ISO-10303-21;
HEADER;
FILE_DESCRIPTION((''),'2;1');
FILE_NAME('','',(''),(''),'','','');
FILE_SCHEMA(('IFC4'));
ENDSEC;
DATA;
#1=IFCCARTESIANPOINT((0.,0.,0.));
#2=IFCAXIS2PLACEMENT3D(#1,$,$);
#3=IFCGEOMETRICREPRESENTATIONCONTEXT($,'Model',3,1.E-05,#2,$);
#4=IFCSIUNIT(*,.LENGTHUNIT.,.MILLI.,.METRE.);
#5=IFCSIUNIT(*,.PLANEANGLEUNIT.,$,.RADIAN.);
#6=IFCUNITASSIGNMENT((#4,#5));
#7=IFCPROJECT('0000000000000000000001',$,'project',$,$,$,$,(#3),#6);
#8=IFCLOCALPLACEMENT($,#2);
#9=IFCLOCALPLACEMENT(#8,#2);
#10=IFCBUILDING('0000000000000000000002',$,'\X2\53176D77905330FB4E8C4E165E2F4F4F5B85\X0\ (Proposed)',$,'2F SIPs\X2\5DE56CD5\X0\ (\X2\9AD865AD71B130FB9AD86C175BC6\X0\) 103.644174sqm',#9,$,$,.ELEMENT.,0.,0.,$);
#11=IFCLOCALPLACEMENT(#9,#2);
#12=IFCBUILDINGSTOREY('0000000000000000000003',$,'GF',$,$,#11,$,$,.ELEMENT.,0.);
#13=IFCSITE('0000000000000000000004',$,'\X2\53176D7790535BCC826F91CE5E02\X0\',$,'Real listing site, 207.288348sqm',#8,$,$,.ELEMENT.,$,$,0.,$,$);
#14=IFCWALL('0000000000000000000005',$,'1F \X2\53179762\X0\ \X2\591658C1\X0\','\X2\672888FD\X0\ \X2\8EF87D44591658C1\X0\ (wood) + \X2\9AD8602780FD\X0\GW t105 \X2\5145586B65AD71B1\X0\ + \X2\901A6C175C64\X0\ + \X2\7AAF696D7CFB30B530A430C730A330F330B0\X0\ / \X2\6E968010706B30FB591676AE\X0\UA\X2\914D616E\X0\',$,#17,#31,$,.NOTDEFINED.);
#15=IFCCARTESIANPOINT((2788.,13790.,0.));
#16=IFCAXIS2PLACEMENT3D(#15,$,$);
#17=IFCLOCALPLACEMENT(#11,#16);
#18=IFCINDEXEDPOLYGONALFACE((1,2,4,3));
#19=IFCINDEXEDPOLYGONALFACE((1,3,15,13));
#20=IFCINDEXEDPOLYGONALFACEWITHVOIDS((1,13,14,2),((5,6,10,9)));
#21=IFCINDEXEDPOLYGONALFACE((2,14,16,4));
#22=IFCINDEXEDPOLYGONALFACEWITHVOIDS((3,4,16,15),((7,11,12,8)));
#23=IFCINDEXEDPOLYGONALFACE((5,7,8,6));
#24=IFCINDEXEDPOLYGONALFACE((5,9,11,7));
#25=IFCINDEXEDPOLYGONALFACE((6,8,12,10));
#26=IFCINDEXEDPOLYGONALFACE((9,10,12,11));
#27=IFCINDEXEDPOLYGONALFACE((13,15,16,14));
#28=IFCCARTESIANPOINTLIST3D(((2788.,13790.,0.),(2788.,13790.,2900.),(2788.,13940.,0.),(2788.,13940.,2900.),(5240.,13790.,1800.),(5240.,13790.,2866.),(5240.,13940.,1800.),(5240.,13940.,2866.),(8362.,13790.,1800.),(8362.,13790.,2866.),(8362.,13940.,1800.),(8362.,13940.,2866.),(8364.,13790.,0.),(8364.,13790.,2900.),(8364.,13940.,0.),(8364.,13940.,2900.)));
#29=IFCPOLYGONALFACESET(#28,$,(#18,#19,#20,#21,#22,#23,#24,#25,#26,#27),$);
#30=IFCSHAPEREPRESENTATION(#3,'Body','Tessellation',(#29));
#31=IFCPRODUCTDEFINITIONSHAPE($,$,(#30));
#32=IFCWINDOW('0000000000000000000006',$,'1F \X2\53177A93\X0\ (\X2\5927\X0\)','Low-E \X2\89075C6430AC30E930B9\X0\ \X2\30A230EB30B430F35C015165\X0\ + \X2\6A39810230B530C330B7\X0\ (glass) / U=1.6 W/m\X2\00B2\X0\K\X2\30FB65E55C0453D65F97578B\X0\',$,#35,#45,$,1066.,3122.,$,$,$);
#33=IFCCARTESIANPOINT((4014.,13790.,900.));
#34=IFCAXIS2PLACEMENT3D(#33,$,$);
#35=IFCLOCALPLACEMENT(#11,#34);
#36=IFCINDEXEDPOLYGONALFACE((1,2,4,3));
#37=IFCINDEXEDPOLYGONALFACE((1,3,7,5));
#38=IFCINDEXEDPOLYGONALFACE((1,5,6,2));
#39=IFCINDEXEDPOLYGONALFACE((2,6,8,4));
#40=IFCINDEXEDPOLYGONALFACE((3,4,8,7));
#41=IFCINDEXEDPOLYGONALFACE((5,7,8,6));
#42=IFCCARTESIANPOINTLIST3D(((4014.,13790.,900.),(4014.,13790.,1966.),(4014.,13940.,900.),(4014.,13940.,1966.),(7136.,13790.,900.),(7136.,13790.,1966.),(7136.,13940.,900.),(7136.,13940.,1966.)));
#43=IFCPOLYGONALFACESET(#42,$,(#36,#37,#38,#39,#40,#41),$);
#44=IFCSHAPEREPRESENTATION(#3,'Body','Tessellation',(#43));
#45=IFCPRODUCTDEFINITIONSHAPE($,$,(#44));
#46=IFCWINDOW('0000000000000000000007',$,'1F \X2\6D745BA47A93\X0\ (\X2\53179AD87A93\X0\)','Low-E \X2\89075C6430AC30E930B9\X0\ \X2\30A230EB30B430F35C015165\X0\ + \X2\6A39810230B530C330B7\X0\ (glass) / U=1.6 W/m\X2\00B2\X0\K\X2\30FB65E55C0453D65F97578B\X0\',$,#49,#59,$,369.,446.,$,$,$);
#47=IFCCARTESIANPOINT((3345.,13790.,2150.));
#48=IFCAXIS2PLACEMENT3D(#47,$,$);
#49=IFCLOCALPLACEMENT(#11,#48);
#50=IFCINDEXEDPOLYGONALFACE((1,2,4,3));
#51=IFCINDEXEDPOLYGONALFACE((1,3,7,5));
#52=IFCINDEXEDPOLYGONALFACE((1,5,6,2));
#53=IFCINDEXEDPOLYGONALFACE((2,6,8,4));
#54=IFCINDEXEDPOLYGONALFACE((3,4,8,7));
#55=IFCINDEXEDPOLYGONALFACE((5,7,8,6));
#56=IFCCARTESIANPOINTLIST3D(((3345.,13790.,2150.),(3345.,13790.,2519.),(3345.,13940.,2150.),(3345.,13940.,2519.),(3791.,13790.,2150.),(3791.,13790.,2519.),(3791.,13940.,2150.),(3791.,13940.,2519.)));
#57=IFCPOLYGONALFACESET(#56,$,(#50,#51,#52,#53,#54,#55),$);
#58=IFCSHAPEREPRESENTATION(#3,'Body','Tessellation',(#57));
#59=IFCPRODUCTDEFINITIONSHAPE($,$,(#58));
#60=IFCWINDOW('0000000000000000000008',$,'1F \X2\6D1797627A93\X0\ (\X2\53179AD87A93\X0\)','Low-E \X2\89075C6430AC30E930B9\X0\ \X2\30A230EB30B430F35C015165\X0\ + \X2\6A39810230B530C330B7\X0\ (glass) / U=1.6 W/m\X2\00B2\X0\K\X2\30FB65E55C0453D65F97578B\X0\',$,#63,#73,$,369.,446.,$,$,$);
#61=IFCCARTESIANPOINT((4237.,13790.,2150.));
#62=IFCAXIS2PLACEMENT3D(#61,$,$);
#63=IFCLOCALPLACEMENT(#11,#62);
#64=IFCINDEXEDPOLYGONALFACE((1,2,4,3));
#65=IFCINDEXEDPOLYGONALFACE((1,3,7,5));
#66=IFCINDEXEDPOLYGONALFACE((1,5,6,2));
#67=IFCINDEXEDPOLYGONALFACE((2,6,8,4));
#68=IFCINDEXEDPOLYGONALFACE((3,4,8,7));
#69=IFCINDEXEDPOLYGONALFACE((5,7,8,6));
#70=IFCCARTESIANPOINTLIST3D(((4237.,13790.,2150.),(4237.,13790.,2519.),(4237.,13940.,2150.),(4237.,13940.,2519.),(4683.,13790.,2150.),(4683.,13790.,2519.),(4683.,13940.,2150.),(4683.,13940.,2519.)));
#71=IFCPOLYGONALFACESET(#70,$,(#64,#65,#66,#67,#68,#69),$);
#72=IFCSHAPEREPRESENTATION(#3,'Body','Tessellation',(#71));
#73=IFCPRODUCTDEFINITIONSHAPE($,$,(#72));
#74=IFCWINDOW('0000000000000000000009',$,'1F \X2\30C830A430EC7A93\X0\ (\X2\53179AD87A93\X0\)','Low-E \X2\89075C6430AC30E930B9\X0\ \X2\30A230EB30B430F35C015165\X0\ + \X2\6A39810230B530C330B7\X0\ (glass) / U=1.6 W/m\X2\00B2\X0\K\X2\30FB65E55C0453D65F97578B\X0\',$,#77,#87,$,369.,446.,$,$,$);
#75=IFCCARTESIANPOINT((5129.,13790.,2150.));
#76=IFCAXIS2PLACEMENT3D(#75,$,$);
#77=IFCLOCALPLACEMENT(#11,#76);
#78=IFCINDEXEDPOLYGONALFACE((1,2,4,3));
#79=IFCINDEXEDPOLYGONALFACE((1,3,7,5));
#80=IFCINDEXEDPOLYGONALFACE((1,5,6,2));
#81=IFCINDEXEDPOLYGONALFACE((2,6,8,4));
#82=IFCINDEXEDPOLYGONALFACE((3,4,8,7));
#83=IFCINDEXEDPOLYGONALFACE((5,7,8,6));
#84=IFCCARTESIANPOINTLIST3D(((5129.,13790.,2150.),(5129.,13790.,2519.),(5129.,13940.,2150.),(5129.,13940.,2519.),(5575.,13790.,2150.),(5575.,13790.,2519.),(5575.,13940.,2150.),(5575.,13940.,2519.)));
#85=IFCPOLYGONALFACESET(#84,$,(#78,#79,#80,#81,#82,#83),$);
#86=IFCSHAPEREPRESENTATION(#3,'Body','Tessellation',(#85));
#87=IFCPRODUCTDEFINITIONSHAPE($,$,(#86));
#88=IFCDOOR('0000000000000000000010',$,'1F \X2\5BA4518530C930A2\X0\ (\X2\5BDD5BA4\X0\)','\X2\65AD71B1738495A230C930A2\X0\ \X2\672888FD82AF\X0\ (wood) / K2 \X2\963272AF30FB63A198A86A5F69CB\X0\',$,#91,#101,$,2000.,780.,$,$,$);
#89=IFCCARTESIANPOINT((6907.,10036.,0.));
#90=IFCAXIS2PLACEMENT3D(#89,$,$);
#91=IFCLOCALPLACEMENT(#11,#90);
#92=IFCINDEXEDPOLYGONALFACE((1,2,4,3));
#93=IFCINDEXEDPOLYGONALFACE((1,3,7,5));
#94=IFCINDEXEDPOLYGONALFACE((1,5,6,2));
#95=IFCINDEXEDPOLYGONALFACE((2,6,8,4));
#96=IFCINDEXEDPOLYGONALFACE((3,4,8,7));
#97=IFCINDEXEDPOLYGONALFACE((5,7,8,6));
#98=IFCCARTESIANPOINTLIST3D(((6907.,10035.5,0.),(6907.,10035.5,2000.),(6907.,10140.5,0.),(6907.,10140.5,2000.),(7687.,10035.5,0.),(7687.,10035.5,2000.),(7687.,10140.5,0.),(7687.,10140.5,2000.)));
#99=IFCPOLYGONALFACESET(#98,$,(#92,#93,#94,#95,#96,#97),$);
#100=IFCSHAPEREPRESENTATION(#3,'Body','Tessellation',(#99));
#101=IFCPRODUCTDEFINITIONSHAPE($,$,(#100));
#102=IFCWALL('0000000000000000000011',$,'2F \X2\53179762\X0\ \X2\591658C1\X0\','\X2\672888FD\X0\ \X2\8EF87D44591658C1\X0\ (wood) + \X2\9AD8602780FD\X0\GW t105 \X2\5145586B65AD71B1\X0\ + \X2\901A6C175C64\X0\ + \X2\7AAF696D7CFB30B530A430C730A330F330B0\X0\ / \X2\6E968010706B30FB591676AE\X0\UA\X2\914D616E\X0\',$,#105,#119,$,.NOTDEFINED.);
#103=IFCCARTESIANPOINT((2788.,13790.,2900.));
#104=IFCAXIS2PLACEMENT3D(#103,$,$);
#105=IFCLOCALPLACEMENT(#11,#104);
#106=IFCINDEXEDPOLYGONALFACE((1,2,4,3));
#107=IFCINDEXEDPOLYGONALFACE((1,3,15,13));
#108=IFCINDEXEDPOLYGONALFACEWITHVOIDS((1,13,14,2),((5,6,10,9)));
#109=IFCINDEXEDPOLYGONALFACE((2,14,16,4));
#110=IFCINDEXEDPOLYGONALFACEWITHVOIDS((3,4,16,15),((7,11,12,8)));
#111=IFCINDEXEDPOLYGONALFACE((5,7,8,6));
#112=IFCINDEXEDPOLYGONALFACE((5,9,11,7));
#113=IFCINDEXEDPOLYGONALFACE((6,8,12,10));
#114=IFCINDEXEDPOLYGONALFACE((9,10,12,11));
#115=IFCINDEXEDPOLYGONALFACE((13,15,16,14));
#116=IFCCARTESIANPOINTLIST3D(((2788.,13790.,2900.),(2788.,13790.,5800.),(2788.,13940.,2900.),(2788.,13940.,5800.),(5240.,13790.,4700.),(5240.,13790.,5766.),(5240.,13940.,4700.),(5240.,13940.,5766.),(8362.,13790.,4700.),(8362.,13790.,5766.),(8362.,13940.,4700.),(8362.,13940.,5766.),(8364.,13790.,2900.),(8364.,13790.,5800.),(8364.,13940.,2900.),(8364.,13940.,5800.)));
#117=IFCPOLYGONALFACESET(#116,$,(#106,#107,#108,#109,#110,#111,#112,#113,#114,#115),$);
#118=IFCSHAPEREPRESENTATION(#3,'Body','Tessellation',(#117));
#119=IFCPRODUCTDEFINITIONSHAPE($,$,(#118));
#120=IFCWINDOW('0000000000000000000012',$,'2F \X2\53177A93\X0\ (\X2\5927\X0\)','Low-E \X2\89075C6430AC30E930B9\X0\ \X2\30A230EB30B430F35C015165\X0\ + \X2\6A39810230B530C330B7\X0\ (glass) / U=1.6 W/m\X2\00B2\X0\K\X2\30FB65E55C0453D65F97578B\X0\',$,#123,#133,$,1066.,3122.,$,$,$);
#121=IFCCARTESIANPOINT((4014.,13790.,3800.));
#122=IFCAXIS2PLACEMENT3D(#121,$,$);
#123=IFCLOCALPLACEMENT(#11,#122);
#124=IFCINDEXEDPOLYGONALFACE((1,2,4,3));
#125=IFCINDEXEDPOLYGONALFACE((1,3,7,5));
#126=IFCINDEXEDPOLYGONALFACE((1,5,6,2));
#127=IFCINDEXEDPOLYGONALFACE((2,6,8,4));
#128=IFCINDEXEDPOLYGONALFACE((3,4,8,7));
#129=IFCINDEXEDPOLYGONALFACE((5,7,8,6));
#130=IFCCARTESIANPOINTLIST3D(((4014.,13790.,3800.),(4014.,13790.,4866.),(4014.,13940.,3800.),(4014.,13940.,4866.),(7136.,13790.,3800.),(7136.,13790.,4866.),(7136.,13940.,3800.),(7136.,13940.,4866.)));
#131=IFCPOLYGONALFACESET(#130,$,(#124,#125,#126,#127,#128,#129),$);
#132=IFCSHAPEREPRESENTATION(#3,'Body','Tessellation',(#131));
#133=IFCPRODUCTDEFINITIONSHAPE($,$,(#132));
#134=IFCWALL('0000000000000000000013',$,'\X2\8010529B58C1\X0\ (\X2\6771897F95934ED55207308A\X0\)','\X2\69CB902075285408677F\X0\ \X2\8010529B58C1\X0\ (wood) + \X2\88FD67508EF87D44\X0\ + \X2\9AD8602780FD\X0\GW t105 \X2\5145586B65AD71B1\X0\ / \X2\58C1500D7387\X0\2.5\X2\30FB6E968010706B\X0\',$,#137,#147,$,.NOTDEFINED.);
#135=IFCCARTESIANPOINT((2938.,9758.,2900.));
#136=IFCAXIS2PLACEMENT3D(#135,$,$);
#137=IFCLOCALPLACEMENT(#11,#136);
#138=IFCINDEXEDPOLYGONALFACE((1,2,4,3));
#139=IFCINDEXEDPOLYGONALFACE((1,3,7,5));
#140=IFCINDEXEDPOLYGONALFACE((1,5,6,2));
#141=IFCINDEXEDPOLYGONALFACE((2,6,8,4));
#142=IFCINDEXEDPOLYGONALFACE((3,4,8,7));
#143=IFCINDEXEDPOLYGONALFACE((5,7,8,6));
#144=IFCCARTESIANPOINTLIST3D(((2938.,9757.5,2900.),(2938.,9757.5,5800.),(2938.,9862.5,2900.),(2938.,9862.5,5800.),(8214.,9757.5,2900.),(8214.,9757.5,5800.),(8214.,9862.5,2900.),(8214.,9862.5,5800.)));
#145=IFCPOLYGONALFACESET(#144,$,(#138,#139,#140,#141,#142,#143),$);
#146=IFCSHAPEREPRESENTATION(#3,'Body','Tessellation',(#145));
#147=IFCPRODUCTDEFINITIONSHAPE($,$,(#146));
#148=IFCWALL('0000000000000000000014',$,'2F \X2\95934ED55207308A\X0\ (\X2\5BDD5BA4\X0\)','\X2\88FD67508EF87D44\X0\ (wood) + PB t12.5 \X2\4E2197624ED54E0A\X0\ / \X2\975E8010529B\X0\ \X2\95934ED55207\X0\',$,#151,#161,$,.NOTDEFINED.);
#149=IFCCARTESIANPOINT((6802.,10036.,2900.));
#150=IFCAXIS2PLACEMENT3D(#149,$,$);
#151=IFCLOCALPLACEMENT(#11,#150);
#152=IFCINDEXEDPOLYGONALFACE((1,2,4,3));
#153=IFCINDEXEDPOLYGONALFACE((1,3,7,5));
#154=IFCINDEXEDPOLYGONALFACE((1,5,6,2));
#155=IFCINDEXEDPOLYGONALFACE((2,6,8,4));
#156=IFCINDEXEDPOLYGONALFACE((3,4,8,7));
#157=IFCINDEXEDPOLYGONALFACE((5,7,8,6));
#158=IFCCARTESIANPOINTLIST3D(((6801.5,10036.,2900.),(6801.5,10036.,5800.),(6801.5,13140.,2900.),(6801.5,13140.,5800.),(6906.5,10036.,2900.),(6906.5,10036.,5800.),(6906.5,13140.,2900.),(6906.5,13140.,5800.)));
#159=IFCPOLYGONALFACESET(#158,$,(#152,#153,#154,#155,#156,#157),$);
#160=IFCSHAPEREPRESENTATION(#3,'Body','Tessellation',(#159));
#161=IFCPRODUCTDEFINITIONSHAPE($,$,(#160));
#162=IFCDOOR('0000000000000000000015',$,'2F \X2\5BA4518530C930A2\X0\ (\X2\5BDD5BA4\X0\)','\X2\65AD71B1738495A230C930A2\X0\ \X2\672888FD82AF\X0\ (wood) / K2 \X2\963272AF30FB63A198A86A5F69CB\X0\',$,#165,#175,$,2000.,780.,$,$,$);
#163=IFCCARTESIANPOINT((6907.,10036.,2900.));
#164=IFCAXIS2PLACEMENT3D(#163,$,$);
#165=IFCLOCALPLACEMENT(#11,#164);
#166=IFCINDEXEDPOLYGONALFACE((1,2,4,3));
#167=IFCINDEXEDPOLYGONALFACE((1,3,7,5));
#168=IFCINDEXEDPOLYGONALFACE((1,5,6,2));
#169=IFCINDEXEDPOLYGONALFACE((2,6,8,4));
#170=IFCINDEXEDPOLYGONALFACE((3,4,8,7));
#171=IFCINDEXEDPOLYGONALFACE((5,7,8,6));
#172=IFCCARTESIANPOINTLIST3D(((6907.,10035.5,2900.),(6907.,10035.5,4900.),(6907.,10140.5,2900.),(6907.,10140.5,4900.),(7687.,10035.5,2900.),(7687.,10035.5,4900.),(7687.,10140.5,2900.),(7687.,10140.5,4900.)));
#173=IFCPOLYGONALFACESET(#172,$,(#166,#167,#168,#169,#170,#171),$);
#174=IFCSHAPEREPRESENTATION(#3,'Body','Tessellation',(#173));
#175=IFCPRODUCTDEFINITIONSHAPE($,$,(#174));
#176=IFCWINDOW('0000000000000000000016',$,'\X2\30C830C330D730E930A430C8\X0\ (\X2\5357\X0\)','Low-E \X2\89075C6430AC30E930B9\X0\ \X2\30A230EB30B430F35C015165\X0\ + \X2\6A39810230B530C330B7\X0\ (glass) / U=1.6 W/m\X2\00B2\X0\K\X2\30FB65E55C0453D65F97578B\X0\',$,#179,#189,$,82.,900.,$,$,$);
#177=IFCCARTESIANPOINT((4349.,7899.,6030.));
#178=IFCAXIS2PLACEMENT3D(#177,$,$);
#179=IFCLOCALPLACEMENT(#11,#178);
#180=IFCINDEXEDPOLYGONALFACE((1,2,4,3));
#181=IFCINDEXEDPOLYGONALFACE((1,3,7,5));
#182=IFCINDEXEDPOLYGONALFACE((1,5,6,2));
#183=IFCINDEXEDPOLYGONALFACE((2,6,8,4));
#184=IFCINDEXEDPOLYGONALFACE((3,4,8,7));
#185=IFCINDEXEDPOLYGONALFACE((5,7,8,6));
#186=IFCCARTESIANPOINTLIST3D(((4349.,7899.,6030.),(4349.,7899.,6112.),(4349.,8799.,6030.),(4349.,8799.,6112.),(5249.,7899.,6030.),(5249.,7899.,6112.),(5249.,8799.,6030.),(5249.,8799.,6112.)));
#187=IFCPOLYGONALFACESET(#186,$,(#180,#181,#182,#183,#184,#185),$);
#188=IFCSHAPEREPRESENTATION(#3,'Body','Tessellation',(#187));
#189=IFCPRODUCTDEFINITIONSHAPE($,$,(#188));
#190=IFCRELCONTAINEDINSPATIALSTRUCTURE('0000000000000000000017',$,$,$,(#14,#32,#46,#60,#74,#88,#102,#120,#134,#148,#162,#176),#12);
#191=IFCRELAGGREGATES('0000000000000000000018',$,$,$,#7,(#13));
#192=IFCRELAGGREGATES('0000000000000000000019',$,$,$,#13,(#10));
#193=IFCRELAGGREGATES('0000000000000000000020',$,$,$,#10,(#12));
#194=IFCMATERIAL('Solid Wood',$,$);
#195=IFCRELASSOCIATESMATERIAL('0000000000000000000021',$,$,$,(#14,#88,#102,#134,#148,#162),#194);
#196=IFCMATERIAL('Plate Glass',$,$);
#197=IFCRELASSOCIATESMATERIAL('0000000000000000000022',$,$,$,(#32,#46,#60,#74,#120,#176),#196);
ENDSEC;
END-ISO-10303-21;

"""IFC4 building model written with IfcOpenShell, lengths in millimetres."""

from ifc_helpers import new_model, si_unit, frame, frame_2d, origin, place, context, project, spatial, rectangle, extrude, material, element, fill, save


model = new_model("IFC4")

# Units and contexts
model_context = context("Model", 3, precision=1e-05, world=origin())
ifc_project = project(units=[si_unit("LENGTHUNIT", "METRE", prefix="MILLI"), si_unit("PLANEANGLEUNIT", "RADIAN")], contexts=[model_context])

# Site, building, storey
site_placement = place(None, origin())
site = spatial("IfcSite", under=ifc_project, at=site_placement, Name="北海道富良野市", ObjectType="Real listing site, 207.288348sqm", CompositionType="ELEMENT", RefElevation=0.0)
building_placement = place(site_placement, origin())
building = spatial("IfcBuilding", under=site, at=building_placement, Name="北海道・二世帯住宅 (Proposed)", ObjectType="2F SIPs工法 (高断熱・高気密) 103.644174sqm", CompositionType="ELEMENT", ElevationOfRefHeight=0.0, ElevationOfTerrain=0.0)
storey_placement = place(building_placement, origin())
storey = spatial("IfcBuildingStorey", under=building, at=storey_placement, Name="GF", CompositionType="ELEMENT", Elevation=0.0)

# Wall, openings, windows
ifc_material_1 = material(Name="Solid Wood")
wall_1_placement = place(storey_placement, frame((2788.0, 13790.0, 0.0)))
wall_1 = element("IfcWall", 1, at=wall_1_placement, inside=storey, material=ifc_material_1, Name="1F 北面 外壁", Description="木製 軸組外壁 (wood) + 高性能GW t105 充填断熱 + 通気層 + 窯業系サイディング / 準耐火・外皮UA配慮", PredefinedType="NOTDEFINED", context=model_context, shape_type="SweptSolid", body=[
    extrude(rectangle(XDim=5576.0, YDim=150.0, at=frame_2d((2788.0, 75.0))), frame((2788.0, 13790.0, 0.0)), (0.0, 0.0, 1.0), 2900.0),
])
opening_1_placement = place(storey_placement, frame((4014.0, 13790.0, 900.0)))
opening_1 = element("IfcOpeningElement", 2, at=opening_1_placement, cuts=wall_1, PredefinedType="NOTDEFINED", context=model_context, shape_type="SweptSolid", body=[
    extrude(rectangle(XDim=3122.0, YDim=150.0, at=frame_2d((1561.0, 75.0))), frame((4014.0, 13790.0, 900.0)), (0.0, 0.0, 1.0), 1066.0),
])
opening_2_placement = place(storey_placement, frame((3345.0, 13790.0, 2150.0)))
opening_2 = element("IfcOpeningElement", 3, at=opening_2_placement, cuts=wall_1, PredefinedType="NOTDEFINED", context=model_context, shape_type="SweptSolid", body=[
    extrude(rectangle(XDim=446.0, YDim=150.0, at=frame_2d((223.0, 75.0))), frame((3345.0, 13790.0, 2150.0)), (0.0, 0.0, 1.0), 369.0),
])
opening_3_placement = place(storey_placement, frame((4237.0, 13790.0, 2150.0)))
opening_3 = element("IfcOpeningElement", 4, at=opening_3_placement, cuts=wall_1, PredefinedType="NOTDEFINED", context=model_context, shape_type="SweptSolid", body=[
    extrude(rectangle(XDim=446.0, YDim=150.0, at=frame_2d((223.0, 75.0))), frame((4237.0, 13790.0, 2150.0)), (0.0, 0.0, 1.0), 369.0),
])
opening_4_placement = place(storey_placement, frame((5129.0, 13790.0, 2150.0)))
opening_4 = element("IfcOpeningElement", 5, at=opening_4_placement, cuts=wall_1, PredefinedType="NOTDEFINED", context=model_context, shape_type="SweptSolid", body=[
    extrude(rectangle(XDim=446.0, YDim=150.0, at=frame_2d((223.0, 75.0))), frame((5129.0, 13790.0, 2150.0)), (0.0, 0.0, 1.0), 369.0),
])
ifc_material_2 = material(Name="Plate Glass")
window_1_placement = place(storey_placement, frame((4014.0, 13790.0, 900.0)))
window_1 = element("IfcWindow", 6, at=window_1_placement, inside=storey, material=ifc_material_2, Name="1F 北窓 (大)", Description="Low-E 複層ガラス アルゴン封入 + 樹脂サッシ (glass) / U=1.6 W/m²K・日射取得型", OverallHeight=1066.0, OverallWidth=3122.0, context=model_context, shape_type="SweptSolid", body=[
    extrude(rectangle(XDim=3122.0, YDim=150.0, at=frame_2d((1561.0, 75.0))), frame((4014.0, 13790.0, 900.0)), (0.0, 0.0, 1.0), 1066.0),
])
fill(opening_1, window_1)
window_2_placement = place(storey_placement, frame((3345.0, 13790.0, 2150.0)))
window_2 = element("IfcWindow", 7, at=window_2_placement, inside=storey, material=ifc_material_2, Name="1F 浴室窓 (北高窓)", Description="Low-E 複層ガラス アルゴン封入 + 樹脂サッシ (glass) / U=1.6 W/m²K・日射取得型", OverallHeight=369.0, OverallWidth=446.0, context=model_context, shape_type="SweptSolid", body=[
    extrude(rectangle(XDim=446.0, YDim=150.0, at=frame_2d((223.0, 75.0))), frame((3345.0, 13790.0, 2150.0)), (0.0, 0.0, 1.0), 369.0),
])
fill(opening_2, window_2)
window_3_placement = place(storey_placement, frame((4237.0, 13790.0, 2150.0)))
window_3 = element("IfcWindow", 8, at=window_3_placement, inside=storey, material=ifc_material_2, Name="1F 洗面窓 (北高窓)", Description="Low-E 複層ガラス アルゴン封入 + 樹脂サッシ (glass) / U=1.6 W/m²K・日射取得型", OverallHeight=369.0, OverallWidth=446.0, context=model_context, shape_type="SweptSolid", body=[
    extrude(rectangle(XDim=446.0, YDim=150.0, at=frame_2d((223.0, 75.0))), frame((4237.0, 13790.0, 2150.0)), (0.0, 0.0, 1.0), 369.0),
])
fill(opening_3, window_3)
window_4_placement = place(storey_placement, frame((5129.0, 13790.0, 2150.0)))
window_4 = element("IfcWindow", 9, at=window_4_placement, inside=storey, material=ifc_material_2, Name="1F トイレ窓 (北高窓)", Description="Low-E 複層ガラス アルゴン封入 + 樹脂サッシ (glass) / U=1.6 W/m²K・日射取得型", OverallHeight=369.0, OverallWidth=446.0, context=model_context, shape_type="SweptSolid", body=[
    extrude(rectangle(XDim=446.0, YDim=150.0, at=frame_2d((223.0, 75.0))), frame((5129.0, 13790.0, 2150.0)), (0.0, 0.0, 1.0), 369.0),
])
fill(opening_4, window_4)

# Door
door_1_placement = place(storey_placement, frame((6907.0, 10036.0, 0.0)))
element("IfcDoor", 10, at=door_1_placement, inside=storey, material=ifc_material_1, Name="1F 室内ドア (寝室)", Description="断熱玄関ドア 木製芯 (wood) / K2 防犯・採風機構", OverallHeight=2000.0, OverallWidth=780.0, context=model_context, shape_type="SweptSolid", body=[
    extrude(rectangle(XDim=780.0, YDim=105.0, at=frame_2d((390.0, 52.0))), frame((6907.0, 10036.0, 0.0)), (0.0, 0.0, 1.0), 2000.0),
])

# Wall, opening, window
wall_2_placement = place(storey_placement, frame((2788.0, 13790.0, 2900.0)))
wall_2 = element("IfcWall", 11, at=wall_2_placement, inside=storey, material=ifc_material_1, Name="2F 北面 外壁", Description="木製 軸組外壁 (wood) + 高性能GW t105 充填断熱 + 通気層 + 窯業系サイディング / 準耐火・外皮UA配慮", PredefinedType="NOTDEFINED", context=model_context, shape_type="SweptSolid", body=[
    extrude(rectangle(XDim=5576.0, YDim=150.0, at=frame_2d((2788.0, 75.0))), frame((2788.0, 13790.0, 2900.0)), (0.0, 0.0, 1.0), 2900.0),
])
opening_5_placement = place(storey_placement, frame((4014.0, 13790.0, 3800.0)))
opening_5 = element("IfcOpeningElement", 12, at=opening_5_placement, cuts=wall_2, PredefinedType="NOTDEFINED", context=model_context, shape_type="SweptSolid", body=[
    extrude(rectangle(XDim=3122.0, YDim=150.0, at=frame_2d((1561.0, 75.0))), frame((4014.0, 13790.0, 3800.0)), (0.0, 0.0, 1.0), 1066.0),
])
window_5_placement = place(storey_placement, frame((4014.0, 13790.0, 3800.0)))
window_5 = element("IfcWindow", 13, at=window_5_placement, inside=storey, material=ifc_material_2, Name="2F 北窓 (大)", Description="Low-E 複層ガラス アルゴン封入 + 樹脂サッシ (glass) / U=1.6 W/m²K・日射取得型", OverallHeight=1066.0, OverallWidth=3122.0, context=model_context, shape_type="SweptSolid", body=[
    extrude(rectangle(XDim=3122.0, YDim=150.0, at=frame_2d((1561.0, 75.0))), frame((4014.0, 13790.0, 3800.0)), (0.0, 0.0, 1.0), 1066.0),
])
fill(opening_5, window_5)

# Walls
wall_3_placement = place(storey_placement, frame((2938.0, 9758.0, 2900.0)))
element("IfcWall", 14, at=wall_3_placement, inside=storey, material=ifc_material_1, Name="耐力壁 (東西間仕切り)", Description="構造用合板 耐力壁 (wood) + 製材軸組 + 高性能GW t105 充填断熱 / 壁倍率2.5・準耐火", PredefinedType="NOTDEFINED", context=model_context, shape_type="SweptSolid", body=[
    extrude(rectangle(XDim=5276.0, YDim=105.0, at=frame_2d((2638.0, 52.0))), frame((2938.0, 9758.0, 2900.0)), (0.0, 0.0, 1.0), 2900.0),
])
wall_4_placement = place(storey_placement, frame((6802.0, 10036.0, 2900.0)))
element("IfcWall", 15, at=wall_4_placement, inside=storey, material=ifc_material_1, Name="2F 間仕切り (寝室)", Description="製材軸組 (wood) + PB t12.5 両面仕上 / 非耐力 間仕切", PredefinedType="NOTDEFINED", context=model_context, shape_type="SweptSolid", body=[
    extrude(rectangle(XDim=105.0, YDim=3104.0, at=frame_2d((52.0, 1552.0))), frame((6802.0, 10036.0, 2900.0)), (0.0, 0.0, 1.0), 2900.0),
])

# Door
door_2_placement = place(storey_placement, frame((6907.0, 10036.0, 2900.0)))
element("IfcDoor", 16, at=door_2_placement, inside=storey, material=ifc_material_1, Name="2F 室内ドア (寝室)", Description="断熱玄関ドア 木製芯 (wood) / K2 防犯・採風機構", OverallHeight=2000.0, OverallWidth=780.0, context=model_context, shape_type="SweptSolid", body=[
    extrude(rectangle(XDim=780.0, YDim=105.0, at=frame_2d((390.0, 52.0))), frame((6907.0, 10036.0, 2900.0)), (0.0, 0.0, 1.0), 2000.0),
])

# Window
window_6_placement = place(storey_placement, frame((4349.0, 7899.0, 6030.0)))
element("IfcWindow", 17, at=window_6_placement, inside=storey, material=ifc_material_2, Name="トップライト (南)", Description="Low-E 複層ガラス アルゴン封入 + 樹脂サッシ (glass) / U=1.6 W/m²K・日射取得型", OverallHeight=82.0, OverallWidth=900.0, context=model_context, shape_type="SweptSolid", body=[
    extrude(rectangle(XDim=900.0, YDim=900.0, at=frame_2d((450.0, 450.0))), frame((4349.0, 7899.0, 6030.0)), (0.0, 0.0, 1.0), 82.0),
])

save(model, "model.ifc")
